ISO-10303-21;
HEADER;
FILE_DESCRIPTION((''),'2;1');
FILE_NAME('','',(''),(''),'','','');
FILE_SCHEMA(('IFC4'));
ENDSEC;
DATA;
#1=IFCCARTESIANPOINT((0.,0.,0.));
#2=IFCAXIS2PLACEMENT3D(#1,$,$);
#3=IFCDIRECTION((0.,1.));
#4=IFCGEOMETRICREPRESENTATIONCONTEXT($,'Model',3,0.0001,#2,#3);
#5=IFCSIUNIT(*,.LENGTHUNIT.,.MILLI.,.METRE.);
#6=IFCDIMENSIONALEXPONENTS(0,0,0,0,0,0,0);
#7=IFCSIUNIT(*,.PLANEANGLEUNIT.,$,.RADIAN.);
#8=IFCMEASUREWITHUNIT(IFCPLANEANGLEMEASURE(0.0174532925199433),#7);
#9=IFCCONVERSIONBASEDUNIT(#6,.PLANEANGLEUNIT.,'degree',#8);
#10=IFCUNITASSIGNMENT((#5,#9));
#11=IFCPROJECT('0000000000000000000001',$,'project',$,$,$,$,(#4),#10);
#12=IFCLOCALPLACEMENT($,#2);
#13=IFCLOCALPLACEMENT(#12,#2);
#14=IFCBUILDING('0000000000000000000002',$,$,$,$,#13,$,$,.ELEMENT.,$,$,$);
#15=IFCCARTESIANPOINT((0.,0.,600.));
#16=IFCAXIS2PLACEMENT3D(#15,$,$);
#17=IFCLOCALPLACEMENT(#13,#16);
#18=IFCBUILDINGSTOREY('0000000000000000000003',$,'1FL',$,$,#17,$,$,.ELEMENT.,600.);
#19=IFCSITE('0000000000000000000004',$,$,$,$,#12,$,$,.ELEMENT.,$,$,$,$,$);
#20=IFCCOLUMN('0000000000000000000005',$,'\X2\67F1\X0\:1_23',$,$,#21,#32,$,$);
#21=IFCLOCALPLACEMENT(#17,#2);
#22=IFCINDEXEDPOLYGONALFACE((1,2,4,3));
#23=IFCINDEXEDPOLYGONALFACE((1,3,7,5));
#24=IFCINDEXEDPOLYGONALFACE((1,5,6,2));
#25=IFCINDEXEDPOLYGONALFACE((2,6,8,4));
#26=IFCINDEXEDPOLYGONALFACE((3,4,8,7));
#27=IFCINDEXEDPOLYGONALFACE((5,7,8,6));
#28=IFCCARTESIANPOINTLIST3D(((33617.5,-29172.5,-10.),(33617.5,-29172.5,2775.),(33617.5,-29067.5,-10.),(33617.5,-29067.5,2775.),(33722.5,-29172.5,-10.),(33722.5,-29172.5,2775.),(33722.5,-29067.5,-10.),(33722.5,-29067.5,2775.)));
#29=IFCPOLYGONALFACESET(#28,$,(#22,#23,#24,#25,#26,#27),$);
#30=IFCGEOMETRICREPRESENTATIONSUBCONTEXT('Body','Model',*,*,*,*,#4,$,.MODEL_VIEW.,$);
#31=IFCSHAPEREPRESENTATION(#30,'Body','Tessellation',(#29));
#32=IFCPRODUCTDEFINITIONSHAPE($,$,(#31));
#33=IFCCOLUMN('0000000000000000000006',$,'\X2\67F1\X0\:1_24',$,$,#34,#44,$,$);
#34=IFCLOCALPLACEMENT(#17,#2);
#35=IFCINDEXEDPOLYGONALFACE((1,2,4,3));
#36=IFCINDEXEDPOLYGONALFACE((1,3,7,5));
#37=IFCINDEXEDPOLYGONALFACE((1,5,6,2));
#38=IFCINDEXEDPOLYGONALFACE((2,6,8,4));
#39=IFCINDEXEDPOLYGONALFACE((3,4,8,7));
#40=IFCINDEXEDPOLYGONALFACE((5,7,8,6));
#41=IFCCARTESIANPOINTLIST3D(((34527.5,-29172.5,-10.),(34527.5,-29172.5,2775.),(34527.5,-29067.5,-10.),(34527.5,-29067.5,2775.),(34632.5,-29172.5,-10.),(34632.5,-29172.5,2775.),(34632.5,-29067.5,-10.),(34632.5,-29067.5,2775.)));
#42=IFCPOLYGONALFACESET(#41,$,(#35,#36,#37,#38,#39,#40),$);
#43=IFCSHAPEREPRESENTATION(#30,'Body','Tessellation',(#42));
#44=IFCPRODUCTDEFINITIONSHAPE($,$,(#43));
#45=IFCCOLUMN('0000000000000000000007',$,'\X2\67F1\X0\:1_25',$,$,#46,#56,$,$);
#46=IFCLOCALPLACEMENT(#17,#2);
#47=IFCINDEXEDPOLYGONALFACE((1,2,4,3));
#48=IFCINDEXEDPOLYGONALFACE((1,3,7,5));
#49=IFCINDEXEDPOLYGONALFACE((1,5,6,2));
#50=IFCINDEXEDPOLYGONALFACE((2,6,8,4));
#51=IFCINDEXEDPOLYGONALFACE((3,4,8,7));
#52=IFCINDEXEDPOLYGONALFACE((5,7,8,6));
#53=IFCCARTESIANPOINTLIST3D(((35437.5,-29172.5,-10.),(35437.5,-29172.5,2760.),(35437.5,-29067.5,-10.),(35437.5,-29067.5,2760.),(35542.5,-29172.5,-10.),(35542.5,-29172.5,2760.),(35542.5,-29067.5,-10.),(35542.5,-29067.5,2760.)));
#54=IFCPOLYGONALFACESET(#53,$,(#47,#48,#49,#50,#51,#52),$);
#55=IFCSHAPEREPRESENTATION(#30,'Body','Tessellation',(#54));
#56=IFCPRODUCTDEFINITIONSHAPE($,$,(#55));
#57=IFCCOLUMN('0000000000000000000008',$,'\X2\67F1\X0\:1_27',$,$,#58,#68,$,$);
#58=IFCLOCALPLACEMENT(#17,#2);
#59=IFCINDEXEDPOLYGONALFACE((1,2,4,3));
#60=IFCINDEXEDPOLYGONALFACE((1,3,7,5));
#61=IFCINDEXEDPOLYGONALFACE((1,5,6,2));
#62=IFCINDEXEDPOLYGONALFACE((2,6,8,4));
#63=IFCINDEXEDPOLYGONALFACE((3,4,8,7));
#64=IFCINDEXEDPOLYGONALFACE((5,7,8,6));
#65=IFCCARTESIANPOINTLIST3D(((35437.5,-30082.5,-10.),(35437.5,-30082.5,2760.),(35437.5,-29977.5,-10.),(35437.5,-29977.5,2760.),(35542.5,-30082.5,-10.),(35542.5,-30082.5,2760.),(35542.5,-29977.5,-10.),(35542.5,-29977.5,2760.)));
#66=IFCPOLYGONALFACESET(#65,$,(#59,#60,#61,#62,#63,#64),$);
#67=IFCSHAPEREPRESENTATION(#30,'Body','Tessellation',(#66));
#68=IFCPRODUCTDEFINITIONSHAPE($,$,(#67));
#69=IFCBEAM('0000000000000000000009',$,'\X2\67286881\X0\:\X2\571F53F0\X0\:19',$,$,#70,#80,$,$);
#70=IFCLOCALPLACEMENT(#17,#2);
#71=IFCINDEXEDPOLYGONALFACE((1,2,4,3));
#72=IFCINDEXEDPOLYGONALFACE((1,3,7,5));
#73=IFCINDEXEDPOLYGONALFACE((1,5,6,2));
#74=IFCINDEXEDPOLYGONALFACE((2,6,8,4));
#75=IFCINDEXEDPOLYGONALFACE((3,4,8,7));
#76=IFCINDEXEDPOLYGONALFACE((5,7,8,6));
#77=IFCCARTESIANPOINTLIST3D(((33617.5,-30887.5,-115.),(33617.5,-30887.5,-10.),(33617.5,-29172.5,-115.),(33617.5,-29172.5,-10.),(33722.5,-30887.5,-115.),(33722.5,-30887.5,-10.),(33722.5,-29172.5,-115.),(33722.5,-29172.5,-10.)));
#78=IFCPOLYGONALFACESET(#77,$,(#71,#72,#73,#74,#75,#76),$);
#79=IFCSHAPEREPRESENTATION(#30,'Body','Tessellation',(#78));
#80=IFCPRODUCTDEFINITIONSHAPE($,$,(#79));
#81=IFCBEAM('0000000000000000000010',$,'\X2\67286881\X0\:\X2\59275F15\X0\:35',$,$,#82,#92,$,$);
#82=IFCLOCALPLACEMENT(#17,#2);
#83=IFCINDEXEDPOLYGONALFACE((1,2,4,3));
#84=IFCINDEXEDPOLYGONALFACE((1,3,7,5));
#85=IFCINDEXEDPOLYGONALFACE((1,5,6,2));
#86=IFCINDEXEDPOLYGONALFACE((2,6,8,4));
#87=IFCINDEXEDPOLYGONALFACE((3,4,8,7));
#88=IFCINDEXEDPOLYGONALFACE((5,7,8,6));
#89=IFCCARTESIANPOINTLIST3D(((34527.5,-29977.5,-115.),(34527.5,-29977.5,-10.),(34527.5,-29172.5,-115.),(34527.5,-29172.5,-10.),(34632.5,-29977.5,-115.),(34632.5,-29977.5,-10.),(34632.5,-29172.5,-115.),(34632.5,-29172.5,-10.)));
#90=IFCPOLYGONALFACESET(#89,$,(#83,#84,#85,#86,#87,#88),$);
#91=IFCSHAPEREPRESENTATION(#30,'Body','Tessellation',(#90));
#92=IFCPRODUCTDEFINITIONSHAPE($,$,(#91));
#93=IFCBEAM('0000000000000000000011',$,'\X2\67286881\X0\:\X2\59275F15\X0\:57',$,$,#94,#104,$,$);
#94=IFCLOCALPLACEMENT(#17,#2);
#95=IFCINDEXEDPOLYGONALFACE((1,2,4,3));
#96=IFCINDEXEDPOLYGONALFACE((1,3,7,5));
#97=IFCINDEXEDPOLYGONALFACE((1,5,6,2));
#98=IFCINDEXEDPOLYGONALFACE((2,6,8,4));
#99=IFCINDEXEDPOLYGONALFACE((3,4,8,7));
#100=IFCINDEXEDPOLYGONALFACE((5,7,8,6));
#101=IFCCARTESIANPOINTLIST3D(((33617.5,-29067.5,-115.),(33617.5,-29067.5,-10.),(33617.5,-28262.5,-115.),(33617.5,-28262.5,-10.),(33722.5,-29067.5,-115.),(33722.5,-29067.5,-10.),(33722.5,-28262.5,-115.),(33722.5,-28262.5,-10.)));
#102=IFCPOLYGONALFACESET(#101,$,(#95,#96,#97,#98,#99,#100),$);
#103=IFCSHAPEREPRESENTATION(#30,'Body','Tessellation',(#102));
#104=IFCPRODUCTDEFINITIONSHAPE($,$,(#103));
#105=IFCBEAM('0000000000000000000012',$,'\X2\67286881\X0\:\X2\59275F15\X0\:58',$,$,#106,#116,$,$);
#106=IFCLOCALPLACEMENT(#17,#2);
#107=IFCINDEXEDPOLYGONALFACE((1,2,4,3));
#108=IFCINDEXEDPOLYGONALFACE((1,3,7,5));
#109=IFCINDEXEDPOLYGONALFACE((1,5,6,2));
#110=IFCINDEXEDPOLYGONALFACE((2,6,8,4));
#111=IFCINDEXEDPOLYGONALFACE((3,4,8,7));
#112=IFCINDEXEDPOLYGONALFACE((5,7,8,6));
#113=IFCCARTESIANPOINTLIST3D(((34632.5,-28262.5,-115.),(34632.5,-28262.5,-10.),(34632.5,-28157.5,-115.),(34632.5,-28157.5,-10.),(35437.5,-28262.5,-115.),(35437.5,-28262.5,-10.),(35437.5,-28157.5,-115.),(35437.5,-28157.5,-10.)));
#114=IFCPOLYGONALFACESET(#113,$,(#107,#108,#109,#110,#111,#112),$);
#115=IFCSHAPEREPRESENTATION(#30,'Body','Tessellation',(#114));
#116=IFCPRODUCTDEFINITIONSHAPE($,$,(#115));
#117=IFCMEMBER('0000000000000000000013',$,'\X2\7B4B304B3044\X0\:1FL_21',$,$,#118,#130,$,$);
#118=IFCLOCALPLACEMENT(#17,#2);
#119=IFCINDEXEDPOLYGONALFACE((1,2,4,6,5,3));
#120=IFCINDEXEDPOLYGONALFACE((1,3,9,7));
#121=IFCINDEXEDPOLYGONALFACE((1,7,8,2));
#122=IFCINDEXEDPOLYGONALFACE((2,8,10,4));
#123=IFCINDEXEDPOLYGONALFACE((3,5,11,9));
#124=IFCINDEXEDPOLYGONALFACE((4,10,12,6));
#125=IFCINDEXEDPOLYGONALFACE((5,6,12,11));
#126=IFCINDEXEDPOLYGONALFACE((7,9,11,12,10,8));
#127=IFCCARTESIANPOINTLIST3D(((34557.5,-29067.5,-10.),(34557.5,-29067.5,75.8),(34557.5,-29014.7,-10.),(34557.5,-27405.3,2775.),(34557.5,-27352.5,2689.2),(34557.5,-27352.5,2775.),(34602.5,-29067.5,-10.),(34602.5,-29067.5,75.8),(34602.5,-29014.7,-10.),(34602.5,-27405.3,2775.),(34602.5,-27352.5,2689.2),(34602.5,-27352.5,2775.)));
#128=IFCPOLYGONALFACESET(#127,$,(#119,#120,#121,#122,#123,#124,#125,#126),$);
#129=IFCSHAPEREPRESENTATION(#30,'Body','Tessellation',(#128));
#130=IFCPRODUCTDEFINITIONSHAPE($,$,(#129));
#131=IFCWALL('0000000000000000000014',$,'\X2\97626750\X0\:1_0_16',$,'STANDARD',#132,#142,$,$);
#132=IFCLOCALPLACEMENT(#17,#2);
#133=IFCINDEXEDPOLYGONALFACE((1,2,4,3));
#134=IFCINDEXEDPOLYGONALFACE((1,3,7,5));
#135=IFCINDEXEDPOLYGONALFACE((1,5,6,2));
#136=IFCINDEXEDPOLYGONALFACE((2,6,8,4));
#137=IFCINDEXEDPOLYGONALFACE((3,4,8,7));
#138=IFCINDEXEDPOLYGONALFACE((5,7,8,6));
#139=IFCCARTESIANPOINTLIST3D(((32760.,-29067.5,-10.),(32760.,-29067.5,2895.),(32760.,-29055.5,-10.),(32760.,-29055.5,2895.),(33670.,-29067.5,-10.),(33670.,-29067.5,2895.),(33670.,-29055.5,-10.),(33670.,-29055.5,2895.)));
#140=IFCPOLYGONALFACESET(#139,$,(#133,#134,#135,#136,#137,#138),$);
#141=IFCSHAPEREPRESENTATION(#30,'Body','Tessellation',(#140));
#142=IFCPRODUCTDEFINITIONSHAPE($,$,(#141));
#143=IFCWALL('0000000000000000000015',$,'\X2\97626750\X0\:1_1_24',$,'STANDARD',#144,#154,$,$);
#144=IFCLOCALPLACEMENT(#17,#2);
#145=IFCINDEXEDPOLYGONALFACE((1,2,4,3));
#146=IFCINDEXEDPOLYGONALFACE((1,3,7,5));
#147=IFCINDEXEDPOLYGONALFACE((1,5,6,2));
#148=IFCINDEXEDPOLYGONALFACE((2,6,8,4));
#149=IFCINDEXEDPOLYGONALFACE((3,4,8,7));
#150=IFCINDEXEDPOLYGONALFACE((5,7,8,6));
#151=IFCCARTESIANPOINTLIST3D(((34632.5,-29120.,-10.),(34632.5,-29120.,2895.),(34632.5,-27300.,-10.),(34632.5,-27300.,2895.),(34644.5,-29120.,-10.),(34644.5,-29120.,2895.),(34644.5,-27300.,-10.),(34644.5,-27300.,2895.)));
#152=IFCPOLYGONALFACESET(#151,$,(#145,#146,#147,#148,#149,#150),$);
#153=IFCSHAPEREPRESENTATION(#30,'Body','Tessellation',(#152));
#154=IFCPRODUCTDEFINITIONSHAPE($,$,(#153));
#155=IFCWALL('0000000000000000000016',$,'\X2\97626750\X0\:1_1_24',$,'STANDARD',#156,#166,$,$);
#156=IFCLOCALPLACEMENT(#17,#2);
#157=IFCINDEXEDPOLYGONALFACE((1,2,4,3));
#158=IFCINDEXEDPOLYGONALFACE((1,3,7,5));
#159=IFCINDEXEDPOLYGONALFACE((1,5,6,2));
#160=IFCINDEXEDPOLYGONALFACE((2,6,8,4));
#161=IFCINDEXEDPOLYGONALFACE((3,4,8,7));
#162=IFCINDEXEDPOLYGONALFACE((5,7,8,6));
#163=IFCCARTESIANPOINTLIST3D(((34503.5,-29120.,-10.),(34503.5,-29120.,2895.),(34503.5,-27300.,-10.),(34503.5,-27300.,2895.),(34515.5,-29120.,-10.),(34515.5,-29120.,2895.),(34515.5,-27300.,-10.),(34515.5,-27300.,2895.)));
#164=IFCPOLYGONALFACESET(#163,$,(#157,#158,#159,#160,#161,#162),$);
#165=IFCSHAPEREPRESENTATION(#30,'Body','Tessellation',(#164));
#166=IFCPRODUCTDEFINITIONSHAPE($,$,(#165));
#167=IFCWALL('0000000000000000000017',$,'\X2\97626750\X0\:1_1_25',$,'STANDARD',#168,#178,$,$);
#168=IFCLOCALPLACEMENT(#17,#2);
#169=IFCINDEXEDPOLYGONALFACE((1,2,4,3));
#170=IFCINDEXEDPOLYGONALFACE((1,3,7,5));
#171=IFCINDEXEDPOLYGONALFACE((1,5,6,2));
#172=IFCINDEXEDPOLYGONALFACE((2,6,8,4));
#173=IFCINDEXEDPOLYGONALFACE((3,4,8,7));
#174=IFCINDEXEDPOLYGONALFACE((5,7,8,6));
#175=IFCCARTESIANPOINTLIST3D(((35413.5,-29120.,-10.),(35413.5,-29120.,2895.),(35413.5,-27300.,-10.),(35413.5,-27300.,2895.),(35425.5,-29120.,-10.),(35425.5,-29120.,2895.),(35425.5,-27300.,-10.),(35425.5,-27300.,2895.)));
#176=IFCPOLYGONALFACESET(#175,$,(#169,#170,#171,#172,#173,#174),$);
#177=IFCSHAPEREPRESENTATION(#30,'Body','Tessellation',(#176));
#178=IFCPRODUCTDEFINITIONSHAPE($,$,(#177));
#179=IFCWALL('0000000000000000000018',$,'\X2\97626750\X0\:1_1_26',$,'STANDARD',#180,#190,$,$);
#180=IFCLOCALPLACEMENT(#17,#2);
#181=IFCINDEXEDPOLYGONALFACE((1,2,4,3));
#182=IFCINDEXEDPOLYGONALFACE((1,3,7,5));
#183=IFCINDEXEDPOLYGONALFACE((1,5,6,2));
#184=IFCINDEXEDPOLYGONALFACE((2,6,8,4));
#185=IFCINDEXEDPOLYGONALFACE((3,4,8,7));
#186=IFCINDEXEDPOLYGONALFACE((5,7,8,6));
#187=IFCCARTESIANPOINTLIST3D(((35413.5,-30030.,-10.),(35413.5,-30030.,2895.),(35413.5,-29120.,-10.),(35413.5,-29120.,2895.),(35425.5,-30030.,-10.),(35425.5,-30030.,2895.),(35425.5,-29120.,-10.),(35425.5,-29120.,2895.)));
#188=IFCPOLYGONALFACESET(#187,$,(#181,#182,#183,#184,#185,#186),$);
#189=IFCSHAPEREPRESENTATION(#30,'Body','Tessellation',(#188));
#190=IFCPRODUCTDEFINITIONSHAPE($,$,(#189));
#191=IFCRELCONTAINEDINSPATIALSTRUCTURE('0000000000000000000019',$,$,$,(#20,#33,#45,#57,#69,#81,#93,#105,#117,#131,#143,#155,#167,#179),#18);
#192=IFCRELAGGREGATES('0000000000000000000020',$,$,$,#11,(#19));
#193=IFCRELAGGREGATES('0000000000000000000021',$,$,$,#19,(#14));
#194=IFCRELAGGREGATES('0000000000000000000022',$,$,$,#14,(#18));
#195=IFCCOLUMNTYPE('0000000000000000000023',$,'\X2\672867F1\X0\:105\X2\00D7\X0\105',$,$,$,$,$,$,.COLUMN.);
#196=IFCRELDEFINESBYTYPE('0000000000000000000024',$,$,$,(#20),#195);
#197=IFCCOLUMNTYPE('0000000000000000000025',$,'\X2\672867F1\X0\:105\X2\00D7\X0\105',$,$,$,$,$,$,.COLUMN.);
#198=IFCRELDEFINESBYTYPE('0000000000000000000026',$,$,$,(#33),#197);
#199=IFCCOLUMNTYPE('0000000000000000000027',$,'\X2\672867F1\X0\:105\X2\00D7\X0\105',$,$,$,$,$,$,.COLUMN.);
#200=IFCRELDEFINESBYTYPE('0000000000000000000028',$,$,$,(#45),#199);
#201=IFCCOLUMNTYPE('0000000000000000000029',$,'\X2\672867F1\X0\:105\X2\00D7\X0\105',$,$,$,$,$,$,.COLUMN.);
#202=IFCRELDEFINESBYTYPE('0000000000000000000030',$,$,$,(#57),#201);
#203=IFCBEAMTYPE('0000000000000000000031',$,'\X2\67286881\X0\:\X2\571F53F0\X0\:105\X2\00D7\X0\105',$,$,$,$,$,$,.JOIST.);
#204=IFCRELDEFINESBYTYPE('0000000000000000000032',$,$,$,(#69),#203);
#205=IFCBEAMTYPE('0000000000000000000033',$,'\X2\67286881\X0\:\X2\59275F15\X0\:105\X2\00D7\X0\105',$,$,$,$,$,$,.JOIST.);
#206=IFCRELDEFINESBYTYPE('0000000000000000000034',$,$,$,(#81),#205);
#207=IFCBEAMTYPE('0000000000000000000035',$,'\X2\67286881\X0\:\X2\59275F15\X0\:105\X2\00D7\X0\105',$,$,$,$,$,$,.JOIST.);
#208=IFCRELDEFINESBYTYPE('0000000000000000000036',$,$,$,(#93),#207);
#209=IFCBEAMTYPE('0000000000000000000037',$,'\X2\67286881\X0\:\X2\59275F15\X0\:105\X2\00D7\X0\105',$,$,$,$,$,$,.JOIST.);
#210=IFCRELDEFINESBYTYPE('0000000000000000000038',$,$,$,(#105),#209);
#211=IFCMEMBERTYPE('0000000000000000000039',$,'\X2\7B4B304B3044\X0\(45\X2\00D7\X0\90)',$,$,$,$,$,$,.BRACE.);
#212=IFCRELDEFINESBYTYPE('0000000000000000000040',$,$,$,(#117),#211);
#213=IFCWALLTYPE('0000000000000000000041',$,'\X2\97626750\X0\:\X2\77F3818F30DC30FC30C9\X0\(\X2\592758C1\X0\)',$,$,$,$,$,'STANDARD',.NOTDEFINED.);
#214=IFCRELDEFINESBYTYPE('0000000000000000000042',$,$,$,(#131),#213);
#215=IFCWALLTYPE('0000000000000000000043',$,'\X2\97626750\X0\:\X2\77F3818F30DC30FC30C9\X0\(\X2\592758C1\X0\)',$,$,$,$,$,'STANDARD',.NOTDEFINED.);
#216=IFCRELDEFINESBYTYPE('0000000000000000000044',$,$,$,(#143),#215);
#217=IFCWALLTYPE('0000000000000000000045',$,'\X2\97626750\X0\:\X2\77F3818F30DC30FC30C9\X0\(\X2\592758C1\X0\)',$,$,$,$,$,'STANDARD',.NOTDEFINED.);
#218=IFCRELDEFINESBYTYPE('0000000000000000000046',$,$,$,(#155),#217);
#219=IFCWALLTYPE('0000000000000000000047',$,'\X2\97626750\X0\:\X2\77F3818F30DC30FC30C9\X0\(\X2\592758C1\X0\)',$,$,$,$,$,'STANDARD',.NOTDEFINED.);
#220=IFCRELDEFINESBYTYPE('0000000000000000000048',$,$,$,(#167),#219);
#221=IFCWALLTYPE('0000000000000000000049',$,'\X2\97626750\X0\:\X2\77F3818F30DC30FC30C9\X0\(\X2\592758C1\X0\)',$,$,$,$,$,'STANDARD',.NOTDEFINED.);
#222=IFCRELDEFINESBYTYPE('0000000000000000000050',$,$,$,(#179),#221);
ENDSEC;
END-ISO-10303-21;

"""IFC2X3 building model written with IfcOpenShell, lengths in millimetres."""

from ifc_helpers import new_model, entity, si_unit, converted_unit, direction, frame, origin, origin_with_axes, origin_2d, place, context, subcontext, project, spatial, polyline, rectangle, outline, extrude, type_object, element, save


model = new_model("IFC2X3")

# Units and contexts
model_context = context("Model", 3, precision=0.0001, world=origin(), true_north=direction((0.0, 1.0)))
body_context = subcontext(model_context, "Body", "Model", "MODEL_VIEW")
ifc_project = project(units=[si_unit("LENGTHUNIT", "METRE", prefix="MILLI"), converted_unit("PLANEANGLEUNIT", "degree", entity("IfcPlaneAngleMeasure", 0.0174532925199433), si_unit("PLANEANGLEUNIT", "RADIAN"), dimensions=[0, 0, 0, 0, 0, 0, 0])], contexts=[model_context])

# Site, building, storey
site_placement = place(None, origin())
site = spatial("IfcSite", under=ifc_project, at=site_placement, CompositionType="ELEMENT")
building_placement = place(site_placement, origin())
building = spatial("IfcBuilding", under=site, at=building_placement, CompositionType="ELEMENT")
storey_placement = place(building_placement, frame((0.0, 0.0, 600.0)))
storey = spatial("IfcBuildingStorey", under=building, at=storey_placement, Name="1FL", CompositionType="ELEMENT", Elevation=600.0)

# Columns
column_type_1 = type_object("IfcColumnType", Name="木柱:105×105", PredefinedType="COLUMN")
column_1_placement = place(storey_placement, frame((33670.0, -29120.0, -10.0)))
element("IfcColumn", 1, at=column_1_placement, inside=storey, type_object=column_type_1, Name="柱:1_23", context=body_context, shape_type="SweptSolid", body=[
    extrude(rectangle(XDim=105.0, YDim=105.0, at=origin_2d()), origin_with_axes(), (0.0, 0.0, 1.0), 2785.0),
])
column_type_2 = type_object("IfcColumnType", Name="木柱:105×105", PredefinedType="COLUMN")
column_2_placement = place(storey_placement, frame((34580.0, -29120.0, -10.0)))
element("IfcColumn", 2, at=column_2_placement, inside=storey, type_object=column_type_2, Name="柱:1_24", context=body_context, shape_type="SweptSolid", body=[
    extrude(rectangle(XDim=105.0, YDim=105.0, at=origin_2d()), origin_with_axes(), (0.0, 0.0, 1.0), 2785.0),
])
column_type_3 = type_object("IfcColumnType", Name="木柱:105×105", PredefinedType="COLUMN")
column_3_placement = place(storey_placement, frame((35490.0, -29120.0, -10.0)))
element("IfcColumn", 3, at=column_3_placement, inside=storey, type_object=column_type_3, Name="柱:1_25", context=body_context, shape_type="SweptSolid", body=[
    extrude(rectangle(XDim=105.0, YDim=105.0, at=origin_2d()), origin_with_axes(), (0.0, 0.0, 1.0), 2770.0),
])
column_type_4 = type_object("IfcColumnType", Name="木柱:105×105", PredefinedType="COLUMN")
column_4_placement = place(storey_placement, frame((35490.0, -30030.0, -10.0)))
element("IfcColumn", 4, at=column_4_placement, inside=storey, type_object=column_type_4, Name="柱:1_27", context=body_context, shape_type="SweptSolid", body=[
    extrude(rectangle(XDim=105.0, YDim=105.0, at=origin_2d()), origin_with_axes(), (0.0, 0.0, 1.0), 2770.0),
])

# Beams
beam_type_1 = type_object("IfcBeamType", Name="木梁:土台:105×105", PredefinedType="JOIST")
beam_1_placement = place(storey_placement, frame((33670.0, -29172.5, -62.5), z_axis=(0.0, -1.0, 0.0), x_axis=(1.0, 0.0, 0.0)))
element("IfcBeam", 5, at=beam_1_placement, inside=storey, type_object=beam_type_1, Name="木梁:土台:19", context=body_context, shape_type="SweptSolid", body=[
    extrude(rectangle(XDim=105.0, YDim=105.0, at=origin_2d()), origin_with_axes(), (0.0, 0.0, 1.0), 1715.0),
])
beam_type_2 = type_object("IfcBeamType", Name="木梁:大引:105×105", PredefinedType="JOIST")
beam_2_placement = place(storey_placement, frame((34580.0, -29172.5, -62.5), z_axis=(0.0, -1.0, 0.0), x_axis=(1.0, 0.0, 0.0)))
element("IfcBeam", 6, at=beam_2_placement, inside=storey, type_object=beam_type_2, Name="木梁:大引:35", context=body_context, shape_type="SweptSolid", body=[
    extrude(rectangle(XDim=105.0, YDim=105.0, at=origin_2d()), origin_with_axes(), (0.0, 0.0, 1.0), 805.0),
])
beam_type_3 = type_object("IfcBeamType", Name="木梁:大引:105×105", PredefinedType="JOIST")
beam_3_placement = place(storey_placement, frame((33670.0, -28262.5, -62.5), z_axis=(0.0, -1.0, 0.0), x_axis=(1.0, 0.0, 0.0)))
element("IfcBeam", 7, at=beam_3_placement, inside=storey, type_object=beam_type_3, Name="木梁:大引:57", context=body_context, shape_type="SweptSolid", body=[
    extrude(rectangle(XDim=105.0, YDim=105.0, at=origin_2d()), origin_with_axes(), (0.0, 0.0, 1.0), 805.0),
])
beam_type_4 = type_object("IfcBeamType", Name="木梁:大引:105×105", PredefinedType="JOIST")
beam_4_placement = place(storey_placement, frame((34632.5, -28210.0, -62.5), z_axis=(1.0, 0.0, 0.0), x_axis=(0.0, 1.0, 0.0)))
element("IfcBeam", 8, at=beam_4_placement, inside=storey, type_object=beam_type_4, Name="木梁:大引:58", context=body_context, shape_type="SweptSolid", body=[
    extrude(rectangle(XDim=105.0, YDim=105.0, at=origin_2d()), origin_with_axes(), (0.0, 0.0, 1.0), 805.0),
])

# Member
member_type = type_object("IfcMemberType", Name="筋かい(45×90)", PredefinedType="BRACE")
member_placement = place(storey_placement, frame((34580.0, -29067.5, -10.0), z_axis=(0.0, 0.524353, 0.851501), x_axis=(0.0, -0.851501, 0.524353)))
element("IfcMember", 9, at=member_placement, inside=storey, type_object=member_type, Name="筋かい:1FL_21", context=body_context, shape_type="SweptSolid", body=[
    extrude(outline(polyline([(0.0, 0.0), (27.7, -45.0), (3197.6, -45.0), (3270.7, 0.0), (3243.0, 45.0), (73.1, 45.0), (0.0, 0.0)])), frame((0.0, -22.5, 0.0), z_axis=(0.0, 1.0, 0.0), x_axis=(0.0, 0.0, 1.0)), (0.0, 0.0, 1.0), 45.0),
])

# Walls
wall_type_1 = type_object("IfcWallType", Name="面材:石膏ボード(大壁)", ElementType="STANDARD", PredefinedType="NOTDEFINED")
wall_1_placement = place(storey_placement, frame((33215.0, -29055.5, -10.0), z_axis=(0.0, -1.0, 0.0), x_axis=(1.0, 0.0, 0.0)))
element("IfcWall", 10, at=wall_1_placement, inside=storey, type_object=wall_type_1, Name="面材:1_0_16", ObjectType="STANDARD", context=body_context, shape_type="SweptSolid", body=[
    extrude(outline(polyline([(455.0, 0.0, 0.0), (-455.0, 0.0, 0.0), (-455.0, 2905.0, 0.0), (455.0, 2905.0, 0.0), (455.0, 0.0, 0.0)])), origin_with_axes(), (0.0, 0.0, 1.0), 12.0),
])
wall_type_2 = type_object("IfcWallType", Name="面材:石膏ボード(大壁)", ElementType="STANDARD", PredefinedType="NOTDEFINED")
wall_2_placement = place(storey_placement, frame((34644.5, -28210.0, -10.0), z_axis=(-1.0, 0.0, 0.0), x_axis=(0.0, -1.0, 0.0)))
element("IfcWall", 11, at=wall_2_placement, inside=storey, type_object=wall_type_2, Name="面材:1_1_24", ObjectType="STANDARD", context=body_context, shape_type="SweptSolid", body=[
    extrude(outline(polyline([(910.0, 0.0, 0.0), (-910.0, 0.0, 0.0), (-910.0, 2905.0, 0.0), (910.0, 2905.0, 0.0), (910.0, 0.0, 0.0)])), origin_with_axes(), (0.0, 0.0, 1.0), 12.0),
])
wall_type_3 = type_object("IfcWallType", Name="面材:石膏ボード(大壁)", ElementType="STANDARD", PredefinedType="NOTDEFINED")
wall_3_placement = place(storey_placement, frame((34515.5, -28210.0, -10.0), z_axis=(-1.0, 0.0, 0.0), x_axis=(0.0, -1.0, 0.0)))
element("IfcWall", 12, at=wall_3_placement, inside=storey, type_object=wall_type_3, Name="面材:1_1_24", ObjectType="STANDARD", context=body_context, shape_type="SweptSolid", body=[
    extrude(outline(polyline([(910.0, 0.0, 0.0), (-910.0, 0.0, 0.0), (-910.0, 2905.0, 0.0), (910.0, 2905.0, 0.0), (910.0, 0.0, 0.0)])), origin_with_axes(), (0.0, 0.0, 1.0), 12.0),
])
wall_type_4 = type_object("IfcWallType", Name="面材:石膏ボード(大壁)", ElementType="STANDARD", PredefinedType="NOTDEFINED")
wall_4_placement = place(storey_placement, frame((35425.5, -28210.0, -10.0), z_axis=(-1.0, 0.0, 0.0), x_axis=(0.0, -1.0, 0.0)))
element("IfcWall", 13, at=wall_4_placement, inside=storey, type_object=wall_type_4, Name="面材:1_1_25", ObjectType="STANDARD", context=body_context, shape_type="SweptSolid", body=[
    extrude(outline(polyline([(910.0, 0.0, 0.0), (-910.0, 0.0, 0.0), (-910.0, 2905.0, 0.0), (910.0, 2905.0, 0.0), (910.0, 0.0, 0.0)])), origin_with_axes(), (0.0, 0.0, 1.0), 12.0),
])
wall_type_5 = type_object("IfcWallType", Name="面材:石膏ボード(大壁)", ElementType="STANDARD", PredefinedType="NOTDEFINED")
wall_5_placement = place(storey_placement, frame((35425.5, -29575.0, -10.0), z_axis=(-1.0, 0.0, 0.0), x_axis=(0.0, -1.0, 0.0)))
element("IfcWall", 14, at=wall_5_placement, inside=storey, type_object=wall_type_5, Name="面材:1_1_26", ObjectType="STANDARD", context=body_context, shape_type="SweptSolid", body=[
    extrude(outline(polyline([(455.0, 0.0, 0.0), (-455.0, 0.0, 0.0), (-455.0, 2905.0, 0.0), (455.0, 2905.0, 0.0), (455.0, 0.0, 0.0)])), origin_with_axes(), (0.0, 0.0, 1.0), 12.0),
])

save(model, "model.ifc")
